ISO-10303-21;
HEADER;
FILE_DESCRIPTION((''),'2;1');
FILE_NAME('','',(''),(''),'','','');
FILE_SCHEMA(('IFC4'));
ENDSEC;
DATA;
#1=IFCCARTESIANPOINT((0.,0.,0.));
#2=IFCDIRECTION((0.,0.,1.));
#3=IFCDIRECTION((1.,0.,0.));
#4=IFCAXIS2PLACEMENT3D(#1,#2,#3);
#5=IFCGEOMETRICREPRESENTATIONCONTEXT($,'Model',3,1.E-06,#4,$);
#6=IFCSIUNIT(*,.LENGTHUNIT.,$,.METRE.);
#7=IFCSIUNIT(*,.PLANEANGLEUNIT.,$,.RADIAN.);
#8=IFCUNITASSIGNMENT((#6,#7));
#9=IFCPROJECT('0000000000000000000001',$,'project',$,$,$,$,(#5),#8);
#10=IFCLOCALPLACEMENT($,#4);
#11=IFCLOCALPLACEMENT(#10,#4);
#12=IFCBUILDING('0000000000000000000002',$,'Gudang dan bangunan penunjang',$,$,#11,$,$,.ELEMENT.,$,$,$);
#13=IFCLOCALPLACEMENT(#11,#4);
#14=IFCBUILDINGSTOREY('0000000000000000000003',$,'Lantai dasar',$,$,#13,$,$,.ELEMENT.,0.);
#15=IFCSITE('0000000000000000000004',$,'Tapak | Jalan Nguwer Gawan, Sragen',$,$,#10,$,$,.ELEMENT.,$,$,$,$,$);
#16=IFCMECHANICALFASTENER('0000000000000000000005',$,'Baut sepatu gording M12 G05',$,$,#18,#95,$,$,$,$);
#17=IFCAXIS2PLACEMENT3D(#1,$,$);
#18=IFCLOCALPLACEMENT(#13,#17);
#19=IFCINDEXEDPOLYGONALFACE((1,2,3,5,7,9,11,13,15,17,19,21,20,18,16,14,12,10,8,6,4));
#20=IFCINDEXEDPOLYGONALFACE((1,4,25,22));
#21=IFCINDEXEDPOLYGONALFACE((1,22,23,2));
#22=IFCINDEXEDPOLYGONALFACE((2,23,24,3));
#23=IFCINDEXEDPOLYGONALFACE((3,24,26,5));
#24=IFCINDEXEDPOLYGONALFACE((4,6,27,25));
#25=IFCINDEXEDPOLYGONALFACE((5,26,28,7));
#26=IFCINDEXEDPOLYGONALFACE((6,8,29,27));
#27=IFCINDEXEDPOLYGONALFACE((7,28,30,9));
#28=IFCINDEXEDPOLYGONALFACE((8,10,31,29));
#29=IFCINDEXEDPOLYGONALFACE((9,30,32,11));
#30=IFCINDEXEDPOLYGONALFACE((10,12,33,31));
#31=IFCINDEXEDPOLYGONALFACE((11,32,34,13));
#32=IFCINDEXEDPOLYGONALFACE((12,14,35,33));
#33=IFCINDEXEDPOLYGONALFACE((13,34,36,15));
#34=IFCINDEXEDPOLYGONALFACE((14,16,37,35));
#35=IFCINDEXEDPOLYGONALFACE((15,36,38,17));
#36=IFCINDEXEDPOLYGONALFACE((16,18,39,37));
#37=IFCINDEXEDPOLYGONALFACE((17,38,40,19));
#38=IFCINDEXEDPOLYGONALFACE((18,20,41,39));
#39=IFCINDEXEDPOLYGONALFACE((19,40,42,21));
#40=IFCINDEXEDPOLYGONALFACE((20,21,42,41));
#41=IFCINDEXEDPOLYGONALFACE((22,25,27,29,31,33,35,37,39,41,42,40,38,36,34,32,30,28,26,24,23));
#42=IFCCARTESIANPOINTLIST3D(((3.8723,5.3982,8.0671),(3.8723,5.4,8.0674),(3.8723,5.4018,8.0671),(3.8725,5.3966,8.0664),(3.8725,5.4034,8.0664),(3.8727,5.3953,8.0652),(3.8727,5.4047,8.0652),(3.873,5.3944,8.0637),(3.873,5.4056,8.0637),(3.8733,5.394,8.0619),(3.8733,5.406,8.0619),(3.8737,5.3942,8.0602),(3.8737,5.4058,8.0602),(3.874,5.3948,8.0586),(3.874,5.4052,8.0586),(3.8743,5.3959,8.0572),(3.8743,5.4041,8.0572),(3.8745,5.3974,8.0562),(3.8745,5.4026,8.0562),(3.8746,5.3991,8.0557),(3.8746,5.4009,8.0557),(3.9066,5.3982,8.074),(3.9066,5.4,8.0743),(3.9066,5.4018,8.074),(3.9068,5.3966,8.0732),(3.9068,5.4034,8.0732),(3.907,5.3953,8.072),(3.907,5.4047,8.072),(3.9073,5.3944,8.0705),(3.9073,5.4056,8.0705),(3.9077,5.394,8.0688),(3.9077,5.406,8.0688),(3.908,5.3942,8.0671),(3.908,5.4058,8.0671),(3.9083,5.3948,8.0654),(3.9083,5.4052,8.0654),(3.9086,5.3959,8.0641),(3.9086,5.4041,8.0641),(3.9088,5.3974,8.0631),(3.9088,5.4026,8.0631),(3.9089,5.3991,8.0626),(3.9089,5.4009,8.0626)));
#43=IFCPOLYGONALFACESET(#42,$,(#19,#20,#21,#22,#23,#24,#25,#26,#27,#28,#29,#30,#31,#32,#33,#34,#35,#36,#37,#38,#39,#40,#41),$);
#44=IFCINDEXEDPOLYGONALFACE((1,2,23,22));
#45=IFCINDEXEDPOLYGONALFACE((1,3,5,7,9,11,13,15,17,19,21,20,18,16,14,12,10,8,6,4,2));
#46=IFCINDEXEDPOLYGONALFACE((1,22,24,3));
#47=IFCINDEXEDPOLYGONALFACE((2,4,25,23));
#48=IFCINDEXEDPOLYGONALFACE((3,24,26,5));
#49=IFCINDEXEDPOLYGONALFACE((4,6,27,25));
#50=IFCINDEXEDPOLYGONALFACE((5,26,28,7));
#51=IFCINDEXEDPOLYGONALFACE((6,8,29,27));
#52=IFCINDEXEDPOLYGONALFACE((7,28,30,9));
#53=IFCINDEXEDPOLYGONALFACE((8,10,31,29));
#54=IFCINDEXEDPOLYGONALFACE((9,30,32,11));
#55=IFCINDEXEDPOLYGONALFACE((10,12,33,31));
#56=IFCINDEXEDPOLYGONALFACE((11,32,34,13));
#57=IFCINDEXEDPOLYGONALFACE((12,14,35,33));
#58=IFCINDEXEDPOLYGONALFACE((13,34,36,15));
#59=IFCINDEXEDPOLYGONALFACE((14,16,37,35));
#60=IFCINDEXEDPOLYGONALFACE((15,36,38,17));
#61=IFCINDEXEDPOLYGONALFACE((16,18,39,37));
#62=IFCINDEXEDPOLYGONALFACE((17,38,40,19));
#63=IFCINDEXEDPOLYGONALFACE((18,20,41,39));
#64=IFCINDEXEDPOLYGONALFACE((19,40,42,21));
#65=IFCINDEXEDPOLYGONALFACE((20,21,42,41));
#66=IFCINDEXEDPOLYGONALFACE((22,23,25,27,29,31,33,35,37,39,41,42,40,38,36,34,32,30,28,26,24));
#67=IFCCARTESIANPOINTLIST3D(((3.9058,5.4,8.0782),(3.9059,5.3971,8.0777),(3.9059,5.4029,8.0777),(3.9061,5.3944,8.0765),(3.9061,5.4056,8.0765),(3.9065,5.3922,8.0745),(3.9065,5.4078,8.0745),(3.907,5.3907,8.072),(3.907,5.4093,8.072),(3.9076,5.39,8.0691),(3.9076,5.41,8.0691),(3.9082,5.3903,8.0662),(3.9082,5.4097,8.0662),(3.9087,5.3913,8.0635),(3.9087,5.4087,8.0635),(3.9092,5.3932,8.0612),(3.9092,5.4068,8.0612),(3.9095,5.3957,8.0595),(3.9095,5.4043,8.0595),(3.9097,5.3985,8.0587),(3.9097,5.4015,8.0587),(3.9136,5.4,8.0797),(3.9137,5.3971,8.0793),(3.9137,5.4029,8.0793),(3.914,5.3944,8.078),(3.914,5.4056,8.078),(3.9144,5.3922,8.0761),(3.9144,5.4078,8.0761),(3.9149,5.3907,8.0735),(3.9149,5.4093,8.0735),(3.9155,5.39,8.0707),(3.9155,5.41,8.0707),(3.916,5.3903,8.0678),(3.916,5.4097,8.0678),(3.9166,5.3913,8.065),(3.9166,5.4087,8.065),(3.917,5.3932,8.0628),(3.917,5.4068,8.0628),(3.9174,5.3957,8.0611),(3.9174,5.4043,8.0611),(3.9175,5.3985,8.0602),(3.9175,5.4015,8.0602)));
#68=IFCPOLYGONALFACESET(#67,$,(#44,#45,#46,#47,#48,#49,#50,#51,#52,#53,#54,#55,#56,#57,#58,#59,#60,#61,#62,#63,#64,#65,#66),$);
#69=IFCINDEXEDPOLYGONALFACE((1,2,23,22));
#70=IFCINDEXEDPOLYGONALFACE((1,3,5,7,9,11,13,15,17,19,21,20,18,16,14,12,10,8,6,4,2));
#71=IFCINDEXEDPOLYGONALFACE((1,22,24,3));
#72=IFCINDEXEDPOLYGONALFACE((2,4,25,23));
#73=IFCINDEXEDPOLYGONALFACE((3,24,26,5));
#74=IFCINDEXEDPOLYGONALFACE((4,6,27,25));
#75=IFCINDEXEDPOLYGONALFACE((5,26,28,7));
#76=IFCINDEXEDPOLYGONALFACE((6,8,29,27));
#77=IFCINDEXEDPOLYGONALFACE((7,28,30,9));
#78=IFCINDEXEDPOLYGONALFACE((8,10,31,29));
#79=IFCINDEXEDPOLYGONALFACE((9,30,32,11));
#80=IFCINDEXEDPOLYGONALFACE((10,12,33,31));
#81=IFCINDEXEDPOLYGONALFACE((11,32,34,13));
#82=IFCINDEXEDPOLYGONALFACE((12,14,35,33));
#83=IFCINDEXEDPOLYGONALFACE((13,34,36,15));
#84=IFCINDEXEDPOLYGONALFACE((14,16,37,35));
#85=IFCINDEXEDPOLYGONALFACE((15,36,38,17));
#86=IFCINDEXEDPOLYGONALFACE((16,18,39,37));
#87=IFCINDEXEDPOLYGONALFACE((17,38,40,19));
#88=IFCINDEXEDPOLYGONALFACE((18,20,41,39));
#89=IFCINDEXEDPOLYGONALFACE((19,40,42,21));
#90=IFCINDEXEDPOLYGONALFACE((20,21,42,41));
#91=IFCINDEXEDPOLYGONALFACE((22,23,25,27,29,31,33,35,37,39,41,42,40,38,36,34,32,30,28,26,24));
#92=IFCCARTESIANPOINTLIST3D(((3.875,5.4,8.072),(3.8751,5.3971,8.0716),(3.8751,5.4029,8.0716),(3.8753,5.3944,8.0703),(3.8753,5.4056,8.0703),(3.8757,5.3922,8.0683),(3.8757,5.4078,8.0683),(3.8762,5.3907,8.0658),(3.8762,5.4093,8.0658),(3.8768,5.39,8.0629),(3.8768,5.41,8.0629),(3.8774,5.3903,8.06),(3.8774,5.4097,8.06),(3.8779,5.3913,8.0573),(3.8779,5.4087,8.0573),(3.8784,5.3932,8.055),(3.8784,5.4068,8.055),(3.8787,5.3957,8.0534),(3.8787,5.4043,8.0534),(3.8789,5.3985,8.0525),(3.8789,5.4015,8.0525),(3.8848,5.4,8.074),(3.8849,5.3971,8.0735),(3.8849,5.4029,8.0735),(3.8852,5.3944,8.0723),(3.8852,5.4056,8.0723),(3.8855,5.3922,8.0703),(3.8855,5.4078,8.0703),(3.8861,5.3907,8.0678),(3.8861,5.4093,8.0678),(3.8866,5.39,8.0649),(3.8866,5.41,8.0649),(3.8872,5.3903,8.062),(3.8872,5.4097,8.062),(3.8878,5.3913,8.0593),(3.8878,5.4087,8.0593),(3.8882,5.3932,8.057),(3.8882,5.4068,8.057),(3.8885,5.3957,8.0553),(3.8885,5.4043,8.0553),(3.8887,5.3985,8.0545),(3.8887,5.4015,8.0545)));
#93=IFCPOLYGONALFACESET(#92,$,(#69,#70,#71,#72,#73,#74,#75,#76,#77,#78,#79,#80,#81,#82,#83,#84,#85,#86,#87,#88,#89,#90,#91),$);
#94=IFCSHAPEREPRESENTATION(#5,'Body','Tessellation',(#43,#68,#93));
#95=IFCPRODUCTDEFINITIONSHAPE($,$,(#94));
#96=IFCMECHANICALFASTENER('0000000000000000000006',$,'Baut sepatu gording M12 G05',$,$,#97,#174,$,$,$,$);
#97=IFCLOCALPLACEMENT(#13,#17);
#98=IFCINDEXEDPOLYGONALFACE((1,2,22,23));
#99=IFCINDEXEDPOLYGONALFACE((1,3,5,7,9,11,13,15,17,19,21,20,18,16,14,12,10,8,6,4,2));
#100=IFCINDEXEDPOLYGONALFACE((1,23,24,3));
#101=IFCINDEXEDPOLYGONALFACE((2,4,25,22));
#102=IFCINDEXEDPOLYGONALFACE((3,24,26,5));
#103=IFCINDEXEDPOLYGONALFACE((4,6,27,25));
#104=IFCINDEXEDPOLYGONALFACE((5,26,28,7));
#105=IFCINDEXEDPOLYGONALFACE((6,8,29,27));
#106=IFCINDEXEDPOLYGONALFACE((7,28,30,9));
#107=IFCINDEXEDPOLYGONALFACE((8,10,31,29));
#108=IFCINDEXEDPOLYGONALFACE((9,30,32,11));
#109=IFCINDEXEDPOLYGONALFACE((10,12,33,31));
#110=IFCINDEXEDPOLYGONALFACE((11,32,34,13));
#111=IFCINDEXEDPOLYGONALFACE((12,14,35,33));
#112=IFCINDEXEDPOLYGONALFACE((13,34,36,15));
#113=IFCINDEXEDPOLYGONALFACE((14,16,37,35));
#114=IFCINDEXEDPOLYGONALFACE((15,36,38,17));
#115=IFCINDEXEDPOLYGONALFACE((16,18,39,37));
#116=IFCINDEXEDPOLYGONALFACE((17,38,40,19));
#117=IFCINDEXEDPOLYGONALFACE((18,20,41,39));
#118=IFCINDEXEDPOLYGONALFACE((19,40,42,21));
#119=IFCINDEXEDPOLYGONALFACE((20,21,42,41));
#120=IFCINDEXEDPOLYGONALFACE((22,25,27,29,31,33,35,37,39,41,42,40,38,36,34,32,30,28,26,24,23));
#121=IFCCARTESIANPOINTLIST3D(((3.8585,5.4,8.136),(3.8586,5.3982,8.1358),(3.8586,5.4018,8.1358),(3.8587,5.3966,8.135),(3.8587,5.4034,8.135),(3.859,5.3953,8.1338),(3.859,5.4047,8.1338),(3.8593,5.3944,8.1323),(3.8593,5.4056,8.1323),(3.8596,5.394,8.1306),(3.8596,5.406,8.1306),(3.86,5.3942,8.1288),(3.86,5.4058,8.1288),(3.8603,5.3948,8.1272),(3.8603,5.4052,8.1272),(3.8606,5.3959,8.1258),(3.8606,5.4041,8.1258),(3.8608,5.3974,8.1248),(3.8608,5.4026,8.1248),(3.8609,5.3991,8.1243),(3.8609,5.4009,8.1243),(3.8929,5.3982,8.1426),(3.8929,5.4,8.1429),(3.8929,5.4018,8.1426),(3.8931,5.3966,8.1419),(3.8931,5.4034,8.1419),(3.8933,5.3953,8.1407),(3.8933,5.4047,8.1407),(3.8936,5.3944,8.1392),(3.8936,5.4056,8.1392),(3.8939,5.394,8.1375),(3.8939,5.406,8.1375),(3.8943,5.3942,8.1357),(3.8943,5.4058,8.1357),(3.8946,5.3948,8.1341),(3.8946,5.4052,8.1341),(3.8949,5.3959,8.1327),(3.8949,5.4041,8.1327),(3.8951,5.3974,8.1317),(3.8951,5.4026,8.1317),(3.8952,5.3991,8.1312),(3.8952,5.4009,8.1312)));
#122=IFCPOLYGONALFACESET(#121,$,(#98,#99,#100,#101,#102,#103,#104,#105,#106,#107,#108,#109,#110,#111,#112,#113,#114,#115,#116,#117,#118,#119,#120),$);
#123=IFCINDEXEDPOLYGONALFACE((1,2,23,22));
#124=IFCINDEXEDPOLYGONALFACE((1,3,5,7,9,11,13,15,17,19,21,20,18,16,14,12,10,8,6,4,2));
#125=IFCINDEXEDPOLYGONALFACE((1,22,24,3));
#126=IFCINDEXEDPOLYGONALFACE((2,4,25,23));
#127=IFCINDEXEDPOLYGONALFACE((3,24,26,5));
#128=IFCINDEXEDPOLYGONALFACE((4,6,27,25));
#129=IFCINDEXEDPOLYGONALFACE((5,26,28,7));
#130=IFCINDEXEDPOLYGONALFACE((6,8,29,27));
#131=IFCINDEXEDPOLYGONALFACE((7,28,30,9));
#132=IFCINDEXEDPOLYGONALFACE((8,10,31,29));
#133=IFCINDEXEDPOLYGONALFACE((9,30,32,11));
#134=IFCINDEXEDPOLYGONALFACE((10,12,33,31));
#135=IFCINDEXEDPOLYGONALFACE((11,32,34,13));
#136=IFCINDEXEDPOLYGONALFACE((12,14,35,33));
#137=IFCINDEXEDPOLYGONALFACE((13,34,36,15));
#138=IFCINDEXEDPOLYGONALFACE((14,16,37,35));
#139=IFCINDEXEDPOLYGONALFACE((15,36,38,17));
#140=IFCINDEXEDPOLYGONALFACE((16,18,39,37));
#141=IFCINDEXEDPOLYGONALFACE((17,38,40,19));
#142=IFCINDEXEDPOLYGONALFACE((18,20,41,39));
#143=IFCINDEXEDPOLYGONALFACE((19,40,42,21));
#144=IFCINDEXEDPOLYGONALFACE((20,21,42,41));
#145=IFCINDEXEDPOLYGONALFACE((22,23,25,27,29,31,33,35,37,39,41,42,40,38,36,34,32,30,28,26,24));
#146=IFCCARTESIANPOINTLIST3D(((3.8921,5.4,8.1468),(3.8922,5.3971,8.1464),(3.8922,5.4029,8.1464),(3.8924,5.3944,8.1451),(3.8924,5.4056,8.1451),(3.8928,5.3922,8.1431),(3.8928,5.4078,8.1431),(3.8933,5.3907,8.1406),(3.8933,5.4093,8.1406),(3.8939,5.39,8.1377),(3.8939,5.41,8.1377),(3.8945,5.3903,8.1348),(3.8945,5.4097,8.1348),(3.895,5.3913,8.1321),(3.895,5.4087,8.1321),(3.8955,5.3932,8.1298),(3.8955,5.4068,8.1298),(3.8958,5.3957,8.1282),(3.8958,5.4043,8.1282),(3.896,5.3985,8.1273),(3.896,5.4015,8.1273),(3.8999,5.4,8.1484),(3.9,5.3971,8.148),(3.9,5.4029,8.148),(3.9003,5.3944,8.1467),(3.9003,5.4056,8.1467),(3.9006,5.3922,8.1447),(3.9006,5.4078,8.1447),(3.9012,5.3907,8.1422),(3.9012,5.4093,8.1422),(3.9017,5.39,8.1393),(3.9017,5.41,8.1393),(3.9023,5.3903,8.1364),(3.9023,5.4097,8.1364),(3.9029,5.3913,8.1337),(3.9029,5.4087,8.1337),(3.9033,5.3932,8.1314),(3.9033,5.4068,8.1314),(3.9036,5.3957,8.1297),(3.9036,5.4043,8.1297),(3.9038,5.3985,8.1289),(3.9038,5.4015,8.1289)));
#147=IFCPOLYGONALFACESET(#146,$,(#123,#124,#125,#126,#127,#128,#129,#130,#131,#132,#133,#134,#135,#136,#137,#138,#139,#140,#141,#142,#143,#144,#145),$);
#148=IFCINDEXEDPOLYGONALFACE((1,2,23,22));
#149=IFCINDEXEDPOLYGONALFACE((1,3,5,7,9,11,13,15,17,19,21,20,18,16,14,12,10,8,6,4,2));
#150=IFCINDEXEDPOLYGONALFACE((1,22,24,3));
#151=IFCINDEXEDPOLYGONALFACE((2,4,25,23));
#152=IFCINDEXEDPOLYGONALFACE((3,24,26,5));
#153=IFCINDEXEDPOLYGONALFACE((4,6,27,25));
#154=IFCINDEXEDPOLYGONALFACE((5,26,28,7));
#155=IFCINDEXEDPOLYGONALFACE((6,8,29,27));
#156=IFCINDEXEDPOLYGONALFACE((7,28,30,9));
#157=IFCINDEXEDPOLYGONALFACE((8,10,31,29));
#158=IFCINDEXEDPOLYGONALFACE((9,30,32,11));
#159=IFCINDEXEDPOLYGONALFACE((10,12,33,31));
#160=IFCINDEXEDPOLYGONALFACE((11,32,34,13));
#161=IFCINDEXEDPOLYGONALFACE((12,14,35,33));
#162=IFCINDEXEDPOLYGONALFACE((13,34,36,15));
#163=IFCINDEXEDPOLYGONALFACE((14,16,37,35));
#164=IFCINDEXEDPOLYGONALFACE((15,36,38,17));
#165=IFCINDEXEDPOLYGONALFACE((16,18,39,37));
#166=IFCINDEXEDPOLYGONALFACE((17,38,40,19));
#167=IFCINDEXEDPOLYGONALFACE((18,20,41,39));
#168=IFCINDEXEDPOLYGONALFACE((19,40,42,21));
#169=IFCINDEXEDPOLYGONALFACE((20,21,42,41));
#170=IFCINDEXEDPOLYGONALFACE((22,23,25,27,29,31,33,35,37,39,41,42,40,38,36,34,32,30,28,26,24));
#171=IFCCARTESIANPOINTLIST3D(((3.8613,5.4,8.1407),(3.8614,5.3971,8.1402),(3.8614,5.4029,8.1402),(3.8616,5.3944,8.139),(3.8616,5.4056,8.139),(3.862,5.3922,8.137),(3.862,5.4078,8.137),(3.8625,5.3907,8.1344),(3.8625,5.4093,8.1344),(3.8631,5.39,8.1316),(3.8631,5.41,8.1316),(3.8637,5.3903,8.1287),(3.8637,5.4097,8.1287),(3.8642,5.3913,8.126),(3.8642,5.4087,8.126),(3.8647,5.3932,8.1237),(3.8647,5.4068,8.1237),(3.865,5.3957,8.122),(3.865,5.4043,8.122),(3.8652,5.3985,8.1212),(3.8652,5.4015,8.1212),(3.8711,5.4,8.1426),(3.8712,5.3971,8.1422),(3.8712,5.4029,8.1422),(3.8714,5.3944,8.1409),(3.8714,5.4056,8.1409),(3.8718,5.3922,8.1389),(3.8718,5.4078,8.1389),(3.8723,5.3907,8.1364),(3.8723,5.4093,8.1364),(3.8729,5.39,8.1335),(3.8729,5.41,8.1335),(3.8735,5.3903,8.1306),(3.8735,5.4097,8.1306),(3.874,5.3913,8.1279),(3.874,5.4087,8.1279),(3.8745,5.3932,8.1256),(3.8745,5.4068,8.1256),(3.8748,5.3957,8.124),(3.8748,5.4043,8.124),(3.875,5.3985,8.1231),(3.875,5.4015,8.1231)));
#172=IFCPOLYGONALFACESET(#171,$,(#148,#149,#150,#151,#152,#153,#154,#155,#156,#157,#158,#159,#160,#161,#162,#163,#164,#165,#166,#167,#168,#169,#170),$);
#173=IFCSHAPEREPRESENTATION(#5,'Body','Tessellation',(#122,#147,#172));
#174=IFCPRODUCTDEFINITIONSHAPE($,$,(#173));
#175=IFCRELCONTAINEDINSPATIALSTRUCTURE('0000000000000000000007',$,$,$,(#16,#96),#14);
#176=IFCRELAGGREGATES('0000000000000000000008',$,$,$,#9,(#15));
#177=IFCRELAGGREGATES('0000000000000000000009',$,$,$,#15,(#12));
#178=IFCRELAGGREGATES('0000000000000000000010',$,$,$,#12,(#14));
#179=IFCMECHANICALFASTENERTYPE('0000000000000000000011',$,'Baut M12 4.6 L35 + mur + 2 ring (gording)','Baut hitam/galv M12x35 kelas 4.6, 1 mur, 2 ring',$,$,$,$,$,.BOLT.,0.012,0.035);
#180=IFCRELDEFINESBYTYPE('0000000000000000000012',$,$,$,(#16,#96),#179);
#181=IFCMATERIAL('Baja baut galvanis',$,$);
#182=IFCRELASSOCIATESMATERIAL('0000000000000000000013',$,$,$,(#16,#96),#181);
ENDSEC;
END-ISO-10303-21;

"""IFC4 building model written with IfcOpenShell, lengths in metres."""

from ifc_helpers import new_model, si_unit, frame, origin_with_axes, place, context, project, spatial, circle, extrude, source, transform, mapped, material, type_object, type_shapes, element, save


model = new_model("IFC4")

# Units and contexts
model_context = context("Model", 3, precision=1e-06, world=origin_with_axes())
ifc_project = project(units=[si_unit("LENGTHUNIT", "METRE"), si_unit("PLANEANGLEUNIT", "RADIAN")], contexts=[model_context])

# Site, building, storey
site_placement = place(None, origin_with_axes())
site = spatial("IfcSite", under=ifc_project, at=site_placement, Name="Tapak | Jalan Nguwer Gawan, Sragen", CompositionType="ELEMENT")
building_placement = place(site_placement, origin_with_axes())
building = spatial("IfcBuilding", under=site, at=building_placement, Name="Gudang dan bangunan penunjang", CompositionType="ELEMENT")
storey_placement = place(building_placement, origin_with_axes())
storey = spatial("IfcBuildingStorey", under=building, at=storey_placement, Name="Lantai dasar", CompositionType="ELEMENT", Elevation=0.0)

# Shared definitions
placement = place(None, origin_with_axes())

# Mechanical fasteners
ifc_material_1 = material(Name="Baja baut galvanis")
mechanical_fastener_type = type_object("IfcMechanicalFastenerType", Name="Baut M12 4.6 L35 + mur + 2 ring (gording)", Description="Baut hitam/galv M12x35 kelas 4.6, 1 mur, 2 ring", NominalDiameter=0.012, NominalLength=0.035, PredefinedType="BOLT")
shared_shape = source(origin_with_axes(), model_context, "Body", "SweptSolid", [
    extrude(circle(Radius=0.006), origin_with_axes(), (0.0, 0.0, 1.0), 0.035),
    extrude(circle(Radius=0.01), frame((0.0, 0.0, -0.008), z_axis=(0.0, 0.0, 1.0), x_axis=(1.0, 0.0, 0.0)), (0.0, 0.0, 1.0), 0.008),
    extrude(circle(Radius=0.01), frame((0.0, 0.0, 0.0214), z_axis=(0.0, 0.0, 1.0), x_axis=(1.0, 0.0, 0.0)), (0.0, 0.0, 1.0), 0.01),
])
type_shapes(mechanical_fastener_type, [shared_shape])
element("IfcMechanicalFastener", 1, at=placement, inside=storey, type_object=mechanical_fastener_type, material=ifc_material_1, Name="Baut sepatu gording M12 G05", context=model_context, shape_type="MappedRepresentation", body=[
    mapped(shared_shape, transform((3.9078, 5.4, 8.0684), x_axis=(-0.196116, 0.0, 0.980581), y_axis=(0.0, 1.0, 0.0), z_axis=(-0.980581, 0.0, -0.196116), scale=1.0)),
])
element("IfcMechanicalFastener", 2, at=placement, inside=storey, type_object=mechanical_fastener_type, material=ifc_material_1, Name="Baut sepatu gording M12 G05", context=model_context, shape_type="MappedRepresentation", body=[
    mapped(shared_shape, transform((3.894, 5.4, 8.137), x_axis=(-0.196116, 0.0, 0.980581), y_axis=(0.0, 1.0, 0.0), z_axis=(-0.980581, 0.0, -0.196116), scale=1.0)),
])

save(model, "model.ifc")
